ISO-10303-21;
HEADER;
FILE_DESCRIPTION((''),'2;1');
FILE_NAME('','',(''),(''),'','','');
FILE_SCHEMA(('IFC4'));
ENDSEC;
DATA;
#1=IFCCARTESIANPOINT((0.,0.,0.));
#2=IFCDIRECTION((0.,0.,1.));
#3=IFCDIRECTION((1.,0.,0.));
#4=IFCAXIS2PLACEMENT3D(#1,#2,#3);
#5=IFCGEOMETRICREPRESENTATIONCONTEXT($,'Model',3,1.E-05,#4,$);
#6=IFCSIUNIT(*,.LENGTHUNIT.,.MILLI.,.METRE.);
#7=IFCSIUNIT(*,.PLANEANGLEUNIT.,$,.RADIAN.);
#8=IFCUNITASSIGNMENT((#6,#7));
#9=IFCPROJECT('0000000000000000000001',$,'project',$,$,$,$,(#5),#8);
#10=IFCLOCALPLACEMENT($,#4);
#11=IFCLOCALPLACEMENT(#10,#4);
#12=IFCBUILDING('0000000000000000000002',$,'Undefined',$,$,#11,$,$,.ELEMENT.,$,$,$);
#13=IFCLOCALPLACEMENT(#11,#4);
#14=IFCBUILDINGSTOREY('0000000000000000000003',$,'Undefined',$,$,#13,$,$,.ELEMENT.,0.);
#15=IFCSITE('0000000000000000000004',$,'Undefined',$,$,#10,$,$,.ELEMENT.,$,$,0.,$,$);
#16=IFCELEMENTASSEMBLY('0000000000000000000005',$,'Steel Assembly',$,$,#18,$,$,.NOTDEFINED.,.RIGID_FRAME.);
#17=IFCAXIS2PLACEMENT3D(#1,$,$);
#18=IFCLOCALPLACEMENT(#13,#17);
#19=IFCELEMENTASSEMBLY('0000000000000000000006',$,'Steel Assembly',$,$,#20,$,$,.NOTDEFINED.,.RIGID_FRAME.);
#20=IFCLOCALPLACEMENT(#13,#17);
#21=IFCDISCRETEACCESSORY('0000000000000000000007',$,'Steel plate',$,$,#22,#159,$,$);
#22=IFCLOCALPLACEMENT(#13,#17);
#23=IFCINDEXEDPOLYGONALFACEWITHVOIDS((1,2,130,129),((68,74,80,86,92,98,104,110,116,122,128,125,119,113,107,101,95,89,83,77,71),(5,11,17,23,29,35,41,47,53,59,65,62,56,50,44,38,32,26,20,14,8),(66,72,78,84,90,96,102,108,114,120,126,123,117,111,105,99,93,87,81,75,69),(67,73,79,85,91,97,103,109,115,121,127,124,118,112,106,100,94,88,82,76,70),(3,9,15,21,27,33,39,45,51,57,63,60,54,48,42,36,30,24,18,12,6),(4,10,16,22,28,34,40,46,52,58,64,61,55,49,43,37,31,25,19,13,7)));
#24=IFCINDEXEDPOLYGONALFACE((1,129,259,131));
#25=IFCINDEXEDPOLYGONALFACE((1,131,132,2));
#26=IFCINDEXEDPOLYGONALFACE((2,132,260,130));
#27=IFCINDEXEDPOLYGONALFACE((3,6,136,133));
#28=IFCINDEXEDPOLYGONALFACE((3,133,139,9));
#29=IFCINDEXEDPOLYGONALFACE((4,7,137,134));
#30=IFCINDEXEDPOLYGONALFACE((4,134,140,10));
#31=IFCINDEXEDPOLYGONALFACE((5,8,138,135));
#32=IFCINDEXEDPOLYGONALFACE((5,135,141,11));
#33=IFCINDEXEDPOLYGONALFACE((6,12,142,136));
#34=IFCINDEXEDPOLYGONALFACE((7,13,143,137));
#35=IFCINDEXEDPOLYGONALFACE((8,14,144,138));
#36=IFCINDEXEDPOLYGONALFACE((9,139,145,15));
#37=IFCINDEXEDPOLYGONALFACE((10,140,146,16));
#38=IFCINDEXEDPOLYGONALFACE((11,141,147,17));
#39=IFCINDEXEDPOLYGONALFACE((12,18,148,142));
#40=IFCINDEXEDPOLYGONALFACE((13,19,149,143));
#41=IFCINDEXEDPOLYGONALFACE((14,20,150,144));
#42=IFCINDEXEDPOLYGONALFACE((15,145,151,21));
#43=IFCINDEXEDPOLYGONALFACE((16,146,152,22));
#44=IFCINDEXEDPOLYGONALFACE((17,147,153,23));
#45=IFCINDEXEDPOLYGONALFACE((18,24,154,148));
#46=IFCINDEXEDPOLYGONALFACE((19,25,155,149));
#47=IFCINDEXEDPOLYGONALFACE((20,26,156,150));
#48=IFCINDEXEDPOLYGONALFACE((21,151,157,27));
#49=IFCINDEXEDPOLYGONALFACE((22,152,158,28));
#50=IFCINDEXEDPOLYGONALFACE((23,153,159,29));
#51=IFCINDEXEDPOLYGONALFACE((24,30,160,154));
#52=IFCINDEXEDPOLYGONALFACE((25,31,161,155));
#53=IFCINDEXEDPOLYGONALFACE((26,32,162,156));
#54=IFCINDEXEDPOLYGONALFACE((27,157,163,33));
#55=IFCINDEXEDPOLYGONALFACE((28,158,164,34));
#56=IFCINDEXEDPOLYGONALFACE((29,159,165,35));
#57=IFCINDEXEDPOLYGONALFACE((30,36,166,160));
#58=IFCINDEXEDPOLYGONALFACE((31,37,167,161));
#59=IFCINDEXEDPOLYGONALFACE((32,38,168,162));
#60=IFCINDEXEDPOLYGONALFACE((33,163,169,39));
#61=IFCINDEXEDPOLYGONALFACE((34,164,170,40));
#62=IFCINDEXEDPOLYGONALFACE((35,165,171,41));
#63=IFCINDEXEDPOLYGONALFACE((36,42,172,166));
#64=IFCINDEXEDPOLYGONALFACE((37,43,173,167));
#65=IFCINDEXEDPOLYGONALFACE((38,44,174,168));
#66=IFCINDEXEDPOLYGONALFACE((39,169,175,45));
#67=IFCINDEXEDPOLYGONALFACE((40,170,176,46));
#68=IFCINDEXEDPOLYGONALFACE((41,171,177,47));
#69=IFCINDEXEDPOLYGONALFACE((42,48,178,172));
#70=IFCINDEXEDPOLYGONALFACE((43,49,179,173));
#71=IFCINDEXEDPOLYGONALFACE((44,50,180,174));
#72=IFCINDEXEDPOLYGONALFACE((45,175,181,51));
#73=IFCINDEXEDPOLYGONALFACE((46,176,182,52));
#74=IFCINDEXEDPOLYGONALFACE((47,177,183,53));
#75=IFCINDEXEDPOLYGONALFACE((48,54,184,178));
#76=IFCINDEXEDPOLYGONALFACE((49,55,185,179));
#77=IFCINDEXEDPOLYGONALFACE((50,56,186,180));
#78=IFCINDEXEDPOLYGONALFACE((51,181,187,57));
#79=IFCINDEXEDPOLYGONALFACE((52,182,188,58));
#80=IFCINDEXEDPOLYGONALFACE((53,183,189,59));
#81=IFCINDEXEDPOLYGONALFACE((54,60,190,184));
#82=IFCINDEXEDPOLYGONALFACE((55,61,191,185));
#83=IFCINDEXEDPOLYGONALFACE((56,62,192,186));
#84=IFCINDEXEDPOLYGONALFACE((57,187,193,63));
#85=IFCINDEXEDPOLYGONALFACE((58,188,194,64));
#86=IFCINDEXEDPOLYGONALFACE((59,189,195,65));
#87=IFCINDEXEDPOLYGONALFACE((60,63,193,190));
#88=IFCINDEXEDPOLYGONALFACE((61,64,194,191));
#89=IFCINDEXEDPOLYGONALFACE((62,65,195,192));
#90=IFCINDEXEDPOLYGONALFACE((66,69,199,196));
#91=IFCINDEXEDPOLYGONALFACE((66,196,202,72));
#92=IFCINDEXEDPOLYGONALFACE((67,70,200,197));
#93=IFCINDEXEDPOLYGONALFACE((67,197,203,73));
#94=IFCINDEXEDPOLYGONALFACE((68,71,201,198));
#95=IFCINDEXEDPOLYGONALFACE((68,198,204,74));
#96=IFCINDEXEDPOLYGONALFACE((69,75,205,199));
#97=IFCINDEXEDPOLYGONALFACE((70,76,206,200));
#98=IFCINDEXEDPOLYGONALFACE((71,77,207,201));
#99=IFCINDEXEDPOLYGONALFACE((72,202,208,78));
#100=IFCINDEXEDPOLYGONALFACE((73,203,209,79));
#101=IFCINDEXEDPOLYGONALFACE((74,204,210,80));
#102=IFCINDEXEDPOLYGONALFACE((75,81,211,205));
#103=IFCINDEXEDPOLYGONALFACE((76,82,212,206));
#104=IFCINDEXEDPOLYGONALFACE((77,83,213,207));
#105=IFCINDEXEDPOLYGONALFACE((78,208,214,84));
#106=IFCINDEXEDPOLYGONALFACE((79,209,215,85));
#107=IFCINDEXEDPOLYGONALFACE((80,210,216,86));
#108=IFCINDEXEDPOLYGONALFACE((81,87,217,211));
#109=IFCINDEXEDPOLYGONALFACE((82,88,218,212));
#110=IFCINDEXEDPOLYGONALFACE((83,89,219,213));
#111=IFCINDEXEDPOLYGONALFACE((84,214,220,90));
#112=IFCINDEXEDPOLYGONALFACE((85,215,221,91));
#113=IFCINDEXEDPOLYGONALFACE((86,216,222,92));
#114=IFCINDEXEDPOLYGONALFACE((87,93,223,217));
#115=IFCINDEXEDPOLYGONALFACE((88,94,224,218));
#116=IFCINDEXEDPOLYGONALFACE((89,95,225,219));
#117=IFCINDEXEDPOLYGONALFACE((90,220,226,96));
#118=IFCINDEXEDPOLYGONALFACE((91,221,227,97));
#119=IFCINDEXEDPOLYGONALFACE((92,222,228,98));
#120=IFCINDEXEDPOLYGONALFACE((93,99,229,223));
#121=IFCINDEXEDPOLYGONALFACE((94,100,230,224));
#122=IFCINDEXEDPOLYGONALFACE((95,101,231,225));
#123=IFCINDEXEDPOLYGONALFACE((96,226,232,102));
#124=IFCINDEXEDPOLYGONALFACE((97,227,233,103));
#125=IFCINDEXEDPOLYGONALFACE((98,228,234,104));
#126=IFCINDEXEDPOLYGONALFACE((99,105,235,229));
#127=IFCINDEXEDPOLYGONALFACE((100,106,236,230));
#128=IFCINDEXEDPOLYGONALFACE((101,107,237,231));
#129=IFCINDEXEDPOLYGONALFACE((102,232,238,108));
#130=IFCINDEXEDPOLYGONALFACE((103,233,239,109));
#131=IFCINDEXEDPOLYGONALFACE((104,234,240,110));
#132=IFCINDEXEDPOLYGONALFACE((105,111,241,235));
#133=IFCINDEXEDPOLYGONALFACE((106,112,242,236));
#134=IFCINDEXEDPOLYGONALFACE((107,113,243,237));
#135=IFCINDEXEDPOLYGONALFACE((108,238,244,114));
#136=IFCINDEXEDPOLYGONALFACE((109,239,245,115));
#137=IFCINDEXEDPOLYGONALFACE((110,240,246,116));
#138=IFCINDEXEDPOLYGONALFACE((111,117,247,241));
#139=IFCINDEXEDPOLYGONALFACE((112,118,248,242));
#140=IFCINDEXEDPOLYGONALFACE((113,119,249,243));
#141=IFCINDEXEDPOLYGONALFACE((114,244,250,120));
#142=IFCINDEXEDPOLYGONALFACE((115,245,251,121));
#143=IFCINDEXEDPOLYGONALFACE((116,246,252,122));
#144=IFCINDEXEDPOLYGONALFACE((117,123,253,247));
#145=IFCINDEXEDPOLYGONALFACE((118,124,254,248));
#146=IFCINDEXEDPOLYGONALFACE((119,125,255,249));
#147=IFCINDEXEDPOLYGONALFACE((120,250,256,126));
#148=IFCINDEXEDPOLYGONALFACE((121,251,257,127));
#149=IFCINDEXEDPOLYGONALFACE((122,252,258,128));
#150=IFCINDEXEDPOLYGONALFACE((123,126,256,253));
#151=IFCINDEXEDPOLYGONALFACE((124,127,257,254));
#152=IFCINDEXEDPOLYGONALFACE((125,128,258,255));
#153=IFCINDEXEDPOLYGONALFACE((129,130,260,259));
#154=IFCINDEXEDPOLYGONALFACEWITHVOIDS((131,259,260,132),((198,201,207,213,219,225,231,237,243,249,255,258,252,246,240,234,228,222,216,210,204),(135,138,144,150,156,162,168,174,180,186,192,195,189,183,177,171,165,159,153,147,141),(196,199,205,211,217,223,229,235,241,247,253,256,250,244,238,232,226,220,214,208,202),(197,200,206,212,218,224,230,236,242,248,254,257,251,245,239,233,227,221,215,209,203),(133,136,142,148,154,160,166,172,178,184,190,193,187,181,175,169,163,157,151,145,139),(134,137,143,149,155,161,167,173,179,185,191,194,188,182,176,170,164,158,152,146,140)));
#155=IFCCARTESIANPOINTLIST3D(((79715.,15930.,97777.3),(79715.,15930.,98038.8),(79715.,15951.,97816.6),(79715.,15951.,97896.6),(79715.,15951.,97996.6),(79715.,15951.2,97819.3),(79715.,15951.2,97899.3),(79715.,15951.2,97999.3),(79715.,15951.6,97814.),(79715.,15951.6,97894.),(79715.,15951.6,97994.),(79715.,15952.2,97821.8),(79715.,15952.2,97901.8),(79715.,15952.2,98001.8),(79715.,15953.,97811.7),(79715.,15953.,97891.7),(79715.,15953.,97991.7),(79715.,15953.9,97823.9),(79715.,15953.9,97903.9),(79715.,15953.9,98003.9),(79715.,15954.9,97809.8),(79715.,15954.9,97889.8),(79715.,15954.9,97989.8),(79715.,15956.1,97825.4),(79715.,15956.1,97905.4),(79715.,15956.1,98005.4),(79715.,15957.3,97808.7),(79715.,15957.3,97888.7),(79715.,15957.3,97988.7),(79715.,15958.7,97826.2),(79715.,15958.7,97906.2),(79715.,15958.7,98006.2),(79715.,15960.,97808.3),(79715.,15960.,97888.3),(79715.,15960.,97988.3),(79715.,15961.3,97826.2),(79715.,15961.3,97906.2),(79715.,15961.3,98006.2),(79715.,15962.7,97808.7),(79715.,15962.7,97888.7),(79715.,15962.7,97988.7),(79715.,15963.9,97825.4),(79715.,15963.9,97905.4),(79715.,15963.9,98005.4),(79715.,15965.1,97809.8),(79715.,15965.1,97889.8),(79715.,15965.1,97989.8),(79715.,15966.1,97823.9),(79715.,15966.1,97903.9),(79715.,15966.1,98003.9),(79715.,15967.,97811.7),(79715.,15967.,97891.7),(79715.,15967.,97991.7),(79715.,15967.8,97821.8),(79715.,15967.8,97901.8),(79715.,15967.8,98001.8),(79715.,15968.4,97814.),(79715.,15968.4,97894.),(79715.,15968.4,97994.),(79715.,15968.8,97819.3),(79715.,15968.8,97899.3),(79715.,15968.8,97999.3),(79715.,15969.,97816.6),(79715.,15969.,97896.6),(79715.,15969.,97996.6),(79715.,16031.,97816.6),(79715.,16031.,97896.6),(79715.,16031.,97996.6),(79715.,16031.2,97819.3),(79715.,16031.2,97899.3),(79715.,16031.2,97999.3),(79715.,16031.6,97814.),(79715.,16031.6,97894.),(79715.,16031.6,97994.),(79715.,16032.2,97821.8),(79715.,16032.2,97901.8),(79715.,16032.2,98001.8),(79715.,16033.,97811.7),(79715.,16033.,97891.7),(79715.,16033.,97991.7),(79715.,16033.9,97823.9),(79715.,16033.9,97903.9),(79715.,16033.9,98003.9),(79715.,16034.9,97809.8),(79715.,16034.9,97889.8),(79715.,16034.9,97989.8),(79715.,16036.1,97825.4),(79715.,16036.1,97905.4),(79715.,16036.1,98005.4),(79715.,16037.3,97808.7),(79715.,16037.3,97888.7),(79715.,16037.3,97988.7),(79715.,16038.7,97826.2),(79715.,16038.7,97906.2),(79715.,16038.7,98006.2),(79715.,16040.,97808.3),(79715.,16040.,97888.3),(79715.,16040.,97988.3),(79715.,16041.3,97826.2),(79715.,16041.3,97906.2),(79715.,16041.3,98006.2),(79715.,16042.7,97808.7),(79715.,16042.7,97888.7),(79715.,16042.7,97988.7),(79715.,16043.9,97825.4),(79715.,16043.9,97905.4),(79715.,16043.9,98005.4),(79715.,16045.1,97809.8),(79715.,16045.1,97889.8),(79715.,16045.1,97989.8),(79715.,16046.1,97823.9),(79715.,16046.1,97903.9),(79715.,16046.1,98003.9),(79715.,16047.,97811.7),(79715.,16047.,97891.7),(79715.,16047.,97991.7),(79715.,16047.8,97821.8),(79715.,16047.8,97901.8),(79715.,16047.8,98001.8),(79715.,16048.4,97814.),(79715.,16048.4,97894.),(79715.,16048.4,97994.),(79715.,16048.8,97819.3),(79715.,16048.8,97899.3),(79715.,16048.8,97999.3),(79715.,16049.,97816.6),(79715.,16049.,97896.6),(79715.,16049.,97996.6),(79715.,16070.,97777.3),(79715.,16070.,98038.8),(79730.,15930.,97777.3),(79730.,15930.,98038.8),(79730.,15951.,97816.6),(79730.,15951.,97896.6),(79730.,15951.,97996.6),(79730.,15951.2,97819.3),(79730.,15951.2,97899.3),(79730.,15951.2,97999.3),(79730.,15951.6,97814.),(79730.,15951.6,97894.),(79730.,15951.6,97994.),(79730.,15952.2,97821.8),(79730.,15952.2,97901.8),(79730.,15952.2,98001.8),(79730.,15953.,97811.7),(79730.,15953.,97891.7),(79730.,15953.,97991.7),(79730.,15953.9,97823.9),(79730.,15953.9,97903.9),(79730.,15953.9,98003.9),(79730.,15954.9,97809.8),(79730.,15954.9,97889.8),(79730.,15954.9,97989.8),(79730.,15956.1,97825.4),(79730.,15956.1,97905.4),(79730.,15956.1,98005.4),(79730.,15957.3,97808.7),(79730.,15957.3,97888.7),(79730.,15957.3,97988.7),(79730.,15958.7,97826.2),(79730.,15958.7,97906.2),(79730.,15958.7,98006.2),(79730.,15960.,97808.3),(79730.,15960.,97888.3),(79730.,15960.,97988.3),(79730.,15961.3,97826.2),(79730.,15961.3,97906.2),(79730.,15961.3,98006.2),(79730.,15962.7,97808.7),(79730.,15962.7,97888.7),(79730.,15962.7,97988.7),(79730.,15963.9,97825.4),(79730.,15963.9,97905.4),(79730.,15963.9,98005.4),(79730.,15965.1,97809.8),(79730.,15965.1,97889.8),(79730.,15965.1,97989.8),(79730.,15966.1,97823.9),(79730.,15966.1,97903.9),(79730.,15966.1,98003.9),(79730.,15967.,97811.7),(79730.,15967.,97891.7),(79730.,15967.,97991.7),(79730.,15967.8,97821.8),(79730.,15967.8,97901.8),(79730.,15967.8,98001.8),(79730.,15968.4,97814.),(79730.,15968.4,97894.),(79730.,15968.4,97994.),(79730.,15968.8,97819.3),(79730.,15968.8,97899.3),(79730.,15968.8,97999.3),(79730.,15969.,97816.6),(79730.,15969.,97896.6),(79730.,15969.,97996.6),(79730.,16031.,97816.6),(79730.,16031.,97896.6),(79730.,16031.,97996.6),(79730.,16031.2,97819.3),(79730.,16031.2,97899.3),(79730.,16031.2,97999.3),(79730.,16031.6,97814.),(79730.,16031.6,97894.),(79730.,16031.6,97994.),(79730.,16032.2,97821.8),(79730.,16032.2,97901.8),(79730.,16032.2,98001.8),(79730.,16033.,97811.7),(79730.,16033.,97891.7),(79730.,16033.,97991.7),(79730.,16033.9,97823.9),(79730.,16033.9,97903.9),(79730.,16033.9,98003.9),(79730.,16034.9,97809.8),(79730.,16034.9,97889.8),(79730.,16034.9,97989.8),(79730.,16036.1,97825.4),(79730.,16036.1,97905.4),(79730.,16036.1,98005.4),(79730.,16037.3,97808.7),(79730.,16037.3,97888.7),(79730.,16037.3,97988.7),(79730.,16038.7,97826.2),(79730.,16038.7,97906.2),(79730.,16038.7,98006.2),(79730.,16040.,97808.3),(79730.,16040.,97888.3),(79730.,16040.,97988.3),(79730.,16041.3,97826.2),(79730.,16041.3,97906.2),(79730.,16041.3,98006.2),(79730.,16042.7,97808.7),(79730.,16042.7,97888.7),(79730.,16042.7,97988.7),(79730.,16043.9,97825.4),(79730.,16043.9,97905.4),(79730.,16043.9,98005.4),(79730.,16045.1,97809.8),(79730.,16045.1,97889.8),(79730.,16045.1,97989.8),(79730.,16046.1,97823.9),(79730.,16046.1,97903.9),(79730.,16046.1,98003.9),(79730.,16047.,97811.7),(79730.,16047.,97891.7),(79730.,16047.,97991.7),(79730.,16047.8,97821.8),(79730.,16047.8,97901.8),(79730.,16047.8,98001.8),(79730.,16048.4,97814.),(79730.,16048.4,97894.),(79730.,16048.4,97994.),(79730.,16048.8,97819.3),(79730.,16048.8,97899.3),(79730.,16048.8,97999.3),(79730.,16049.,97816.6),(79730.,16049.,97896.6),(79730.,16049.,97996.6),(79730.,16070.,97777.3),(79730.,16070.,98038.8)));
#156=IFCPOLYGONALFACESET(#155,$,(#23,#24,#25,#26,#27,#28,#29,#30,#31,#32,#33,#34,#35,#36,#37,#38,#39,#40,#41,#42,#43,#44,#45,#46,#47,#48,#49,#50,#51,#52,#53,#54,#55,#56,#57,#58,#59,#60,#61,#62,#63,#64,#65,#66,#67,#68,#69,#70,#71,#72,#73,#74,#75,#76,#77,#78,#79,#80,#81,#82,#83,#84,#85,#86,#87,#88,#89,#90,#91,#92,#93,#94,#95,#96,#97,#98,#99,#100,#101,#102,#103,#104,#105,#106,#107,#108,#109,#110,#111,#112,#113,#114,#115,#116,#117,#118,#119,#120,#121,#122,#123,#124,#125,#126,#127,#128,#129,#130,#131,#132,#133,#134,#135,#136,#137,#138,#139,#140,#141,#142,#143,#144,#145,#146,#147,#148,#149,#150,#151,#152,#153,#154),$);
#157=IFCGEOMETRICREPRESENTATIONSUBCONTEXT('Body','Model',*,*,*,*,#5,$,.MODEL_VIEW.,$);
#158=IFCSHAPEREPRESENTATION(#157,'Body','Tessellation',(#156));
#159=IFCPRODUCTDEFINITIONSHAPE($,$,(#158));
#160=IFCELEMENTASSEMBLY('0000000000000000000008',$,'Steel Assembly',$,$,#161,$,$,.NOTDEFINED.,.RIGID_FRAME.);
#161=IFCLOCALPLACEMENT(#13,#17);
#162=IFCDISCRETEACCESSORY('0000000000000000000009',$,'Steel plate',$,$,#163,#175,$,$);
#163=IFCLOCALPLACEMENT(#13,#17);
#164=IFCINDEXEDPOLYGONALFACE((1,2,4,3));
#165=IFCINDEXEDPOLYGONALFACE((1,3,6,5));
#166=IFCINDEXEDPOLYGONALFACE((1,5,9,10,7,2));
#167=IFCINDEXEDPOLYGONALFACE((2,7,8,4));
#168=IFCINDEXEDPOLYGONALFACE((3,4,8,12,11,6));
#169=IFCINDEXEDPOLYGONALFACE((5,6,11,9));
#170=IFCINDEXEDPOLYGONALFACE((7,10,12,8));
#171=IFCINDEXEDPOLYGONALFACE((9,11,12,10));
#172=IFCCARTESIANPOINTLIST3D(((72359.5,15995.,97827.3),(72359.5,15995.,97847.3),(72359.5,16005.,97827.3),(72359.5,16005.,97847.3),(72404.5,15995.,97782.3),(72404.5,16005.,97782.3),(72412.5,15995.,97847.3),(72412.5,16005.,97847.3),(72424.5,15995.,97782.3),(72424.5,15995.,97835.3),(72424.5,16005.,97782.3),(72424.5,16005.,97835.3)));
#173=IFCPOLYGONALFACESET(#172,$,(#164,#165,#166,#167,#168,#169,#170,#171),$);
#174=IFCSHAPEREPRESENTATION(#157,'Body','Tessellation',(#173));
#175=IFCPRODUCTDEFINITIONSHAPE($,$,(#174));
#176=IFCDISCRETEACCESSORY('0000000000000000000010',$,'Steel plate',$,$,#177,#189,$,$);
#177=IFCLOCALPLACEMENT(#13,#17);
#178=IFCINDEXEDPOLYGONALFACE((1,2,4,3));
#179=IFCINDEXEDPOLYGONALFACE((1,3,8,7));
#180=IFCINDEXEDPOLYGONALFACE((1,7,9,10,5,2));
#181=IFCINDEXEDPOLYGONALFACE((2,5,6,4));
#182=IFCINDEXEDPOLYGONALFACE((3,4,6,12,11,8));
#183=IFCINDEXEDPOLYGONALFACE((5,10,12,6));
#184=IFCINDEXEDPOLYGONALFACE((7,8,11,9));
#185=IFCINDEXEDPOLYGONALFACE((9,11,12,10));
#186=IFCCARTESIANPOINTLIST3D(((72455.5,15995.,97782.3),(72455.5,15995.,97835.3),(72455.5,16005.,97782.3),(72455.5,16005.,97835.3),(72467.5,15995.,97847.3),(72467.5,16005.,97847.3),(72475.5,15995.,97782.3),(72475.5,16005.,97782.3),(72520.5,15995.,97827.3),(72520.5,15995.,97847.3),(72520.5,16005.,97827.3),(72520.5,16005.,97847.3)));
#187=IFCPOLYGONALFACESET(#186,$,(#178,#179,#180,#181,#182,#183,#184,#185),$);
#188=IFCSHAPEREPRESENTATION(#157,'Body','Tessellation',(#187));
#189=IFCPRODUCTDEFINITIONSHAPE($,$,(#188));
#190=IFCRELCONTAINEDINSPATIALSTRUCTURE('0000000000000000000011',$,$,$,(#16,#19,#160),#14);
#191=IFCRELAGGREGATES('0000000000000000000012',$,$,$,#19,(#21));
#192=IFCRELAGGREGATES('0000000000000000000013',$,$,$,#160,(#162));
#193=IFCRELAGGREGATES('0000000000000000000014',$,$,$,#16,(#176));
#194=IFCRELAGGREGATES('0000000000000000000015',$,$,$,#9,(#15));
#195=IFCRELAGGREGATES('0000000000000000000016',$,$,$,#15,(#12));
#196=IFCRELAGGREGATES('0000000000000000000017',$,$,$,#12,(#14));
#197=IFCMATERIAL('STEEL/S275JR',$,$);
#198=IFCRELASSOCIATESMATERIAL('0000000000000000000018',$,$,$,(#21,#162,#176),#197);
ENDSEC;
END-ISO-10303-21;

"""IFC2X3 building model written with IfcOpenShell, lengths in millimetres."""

from ifc_helpers import new_model, si_unit, frame, origin_with_axes, origin_2d_with_axis, place, context, subcontext, project, spatial, polyline, circle, outline, extrude, source, transform, mapped, material, element, aggregate, save


model = new_model("IFC2X3")

# Units and contexts
model_context = context("Model", 3, precision=1e-05, world=origin_with_axes())
body_context = subcontext(model_context, "Body", "Model", "MODEL_VIEW")
ifc_project = project(units=[si_unit("LENGTHUNIT", "METRE", prefix="MILLI"), si_unit("PLANEANGLEUNIT", "RADIAN")], contexts=[model_context])

# Site, building, storey
site_placement = place(None, origin_with_axes())
site = spatial("IfcSite", under=ifc_project, at=site_placement, Name="Undefined", CompositionType="ELEMENT", RefElevation=0.0)
building_placement = place(site_placement, origin_with_axes())
building = spatial("IfcBuilding", under=site, at=building_placement, Name="Undefined", CompositionType="ELEMENT")
storey_placement = place(building_placement, origin_with_axes())
storey = spatial("IfcBuildingStorey", under=building, at=storey_placement, Name="Undefined", CompositionType="ELEMENT", Elevation=0.0)

# Shared definitions
ifc_material_1 = material(Name="STEEL/S275JR")

# Element assemblies, discrete accessory, opening
assembly_1_placement = place(storey_placement, origin_with_axes())
assembly_1 = element("IfcElementAssembly", 1, at=assembly_1_placement, inside=storey, Name="Steel Assembly", AssemblyPlace="NOTDEFINED", PredefinedType="RIGID_FRAME")
assembly_2_placement = place(storey_placement, origin_with_axes())
assembly_2 = element("IfcElementAssembly", 2, at=assembly_2_placement, inside=storey, Name="Steel Assembly", AssemblyPlace="NOTDEFINED", PredefinedType="RIGID_FRAME")
discrete_accessory_1_placement = place(assembly_2_placement, frame((79722.5, 15930.0, 98038.8), z_axis=(-1.0, 0.0, 0.0), x_axis=(0.0, 1.0, 0.0)))
discrete_accessory_1 = element("IfcDiscreteAccessory", 3, at=discrete_accessory_1_placement, material=ifc_material_1, Name="Steel plate", context=body_context, shape_type="SweptSolid", body=[
    extrude(outline(polyline([(0.0, 0.0), (140.0, 0.0), (140.0, 261.5), (0.0, 261.5), (0.0, 0.0)])), frame((0.0, 0.0, -7.5), z_axis=(0.0, 0.0, 1.0), x_axis=(1.0, 0.0, 0.0)), (0.0, 0.0, 1.0), 15.0),
])
shared_shape_1 = source(origin_with_axes(), body_context, "Body", "SweptSolid", [
    extrude(circle(Radius=9.0, at=origin_2d_with_axis()), frame((0.0, 0.9, 0.0), z_axis=(0.0, 1.0, 0.0), x_axis=(1.0, 0.0, 0.0)), (0.0, 0.0, 1.0), 16.1),
])
opening_1_placement = place(assembly_2_placement, frame((79714.0, 16000.0, 97997.3), z_axis=(0.0, -1.0, 0.0), x_axis=(0.0, 0.0, -1.0)))
element("IfcOpeningElement", 4, at=opening_1_placement, cuts=discrete_accessory_1, ObjectType="Opening", context=body_context, shape_type="MappedRepresentation", body=[
    mapped(shared_shape_1, transform((0.0, 0.0, -40.0))),
    mapped(shared_shape_1, transform((100.0, 0.0, -40.0))),
    mapped(shared_shape_1, transform((180.0, 0.0, -40.0))),
    mapped(shared_shape_1, transform((0.0, 0.0, 40.0))),
    mapped(shared_shape_1, transform((100.0, 0.0, 40.0))),
    mapped(shared_shape_1, transform((180.0, 0.0, 40.0))),
])
aggregate(assembly_2, [discrete_accessory_1])

# Element assembly, discrete accessory
assembly_3_placement = place(storey_placement, origin_with_axes())
assembly_3 = element("IfcElementAssembly", 5, at=assembly_3_placement, inside=storey, Name="Steel Assembly", AssemblyPlace="NOTDEFINED", PredefinedType="RIGID_FRAME")
discrete_accessory_2_placement = place(assembly_3_placement, frame((72359.5, 16000.0, 97847.3), z_axis=(0.0, 1.0, 0.0), x_axis=(1.0, 0.0, 0.0)))
discrete_accessory_2 = element("IfcDiscreteAccessory", 6, at=discrete_accessory_2_placement, material=ifc_material_1, Name="Steel plate", context=body_context, shape_type="SweptSolid", body=[
    extrude(outline(polyline([(0.0, 0.0), (53.0, 0.0), (65.0, 12.0), (65.0, 65.0), (45.0, 65.0), (0.0, 20.0), (0.0, 0.0)])), frame((0.0, 0.0, -5.0), z_axis=(0.0, 0.0, 1.0), x_axis=(1.0, 0.0, 0.0)), (0.0, 0.0, 1.0), 10.0),
])

# Discrete accessory
discrete_accessory_3_placement = place(assembly_1_placement, frame((72520.5, 16000.0, 97847.3), z_axis=(0.0, -1.0, 0.0), x_axis=(-1.0, 0.0, 0.0)))
discrete_accessory_3 = element("IfcDiscreteAccessory", 7, at=discrete_accessory_3_placement, material=ifc_material_1, Name="Steel plate", context=body_context, shape_type="SweptSolid", body=[
    extrude(outline(polyline([(0.0, 0.0), (53.0, 0.0), (65.0, 12.0), (65.0, 65.0), (45.0, 65.0), (0.0, 20.0), (0.0, 0.0)])), frame((0.0, 0.0, -5.0), z_axis=(0.0, 0.0, 1.0), x_axis=(1.0, 0.0, 0.0)), (0.0, 0.0, 1.0), 10.0),
])

aggregate(assembly_3, [discrete_accessory_2])
aggregate(assembly_1, [discrete_accessory_3])

save(model, "model.ifc")
